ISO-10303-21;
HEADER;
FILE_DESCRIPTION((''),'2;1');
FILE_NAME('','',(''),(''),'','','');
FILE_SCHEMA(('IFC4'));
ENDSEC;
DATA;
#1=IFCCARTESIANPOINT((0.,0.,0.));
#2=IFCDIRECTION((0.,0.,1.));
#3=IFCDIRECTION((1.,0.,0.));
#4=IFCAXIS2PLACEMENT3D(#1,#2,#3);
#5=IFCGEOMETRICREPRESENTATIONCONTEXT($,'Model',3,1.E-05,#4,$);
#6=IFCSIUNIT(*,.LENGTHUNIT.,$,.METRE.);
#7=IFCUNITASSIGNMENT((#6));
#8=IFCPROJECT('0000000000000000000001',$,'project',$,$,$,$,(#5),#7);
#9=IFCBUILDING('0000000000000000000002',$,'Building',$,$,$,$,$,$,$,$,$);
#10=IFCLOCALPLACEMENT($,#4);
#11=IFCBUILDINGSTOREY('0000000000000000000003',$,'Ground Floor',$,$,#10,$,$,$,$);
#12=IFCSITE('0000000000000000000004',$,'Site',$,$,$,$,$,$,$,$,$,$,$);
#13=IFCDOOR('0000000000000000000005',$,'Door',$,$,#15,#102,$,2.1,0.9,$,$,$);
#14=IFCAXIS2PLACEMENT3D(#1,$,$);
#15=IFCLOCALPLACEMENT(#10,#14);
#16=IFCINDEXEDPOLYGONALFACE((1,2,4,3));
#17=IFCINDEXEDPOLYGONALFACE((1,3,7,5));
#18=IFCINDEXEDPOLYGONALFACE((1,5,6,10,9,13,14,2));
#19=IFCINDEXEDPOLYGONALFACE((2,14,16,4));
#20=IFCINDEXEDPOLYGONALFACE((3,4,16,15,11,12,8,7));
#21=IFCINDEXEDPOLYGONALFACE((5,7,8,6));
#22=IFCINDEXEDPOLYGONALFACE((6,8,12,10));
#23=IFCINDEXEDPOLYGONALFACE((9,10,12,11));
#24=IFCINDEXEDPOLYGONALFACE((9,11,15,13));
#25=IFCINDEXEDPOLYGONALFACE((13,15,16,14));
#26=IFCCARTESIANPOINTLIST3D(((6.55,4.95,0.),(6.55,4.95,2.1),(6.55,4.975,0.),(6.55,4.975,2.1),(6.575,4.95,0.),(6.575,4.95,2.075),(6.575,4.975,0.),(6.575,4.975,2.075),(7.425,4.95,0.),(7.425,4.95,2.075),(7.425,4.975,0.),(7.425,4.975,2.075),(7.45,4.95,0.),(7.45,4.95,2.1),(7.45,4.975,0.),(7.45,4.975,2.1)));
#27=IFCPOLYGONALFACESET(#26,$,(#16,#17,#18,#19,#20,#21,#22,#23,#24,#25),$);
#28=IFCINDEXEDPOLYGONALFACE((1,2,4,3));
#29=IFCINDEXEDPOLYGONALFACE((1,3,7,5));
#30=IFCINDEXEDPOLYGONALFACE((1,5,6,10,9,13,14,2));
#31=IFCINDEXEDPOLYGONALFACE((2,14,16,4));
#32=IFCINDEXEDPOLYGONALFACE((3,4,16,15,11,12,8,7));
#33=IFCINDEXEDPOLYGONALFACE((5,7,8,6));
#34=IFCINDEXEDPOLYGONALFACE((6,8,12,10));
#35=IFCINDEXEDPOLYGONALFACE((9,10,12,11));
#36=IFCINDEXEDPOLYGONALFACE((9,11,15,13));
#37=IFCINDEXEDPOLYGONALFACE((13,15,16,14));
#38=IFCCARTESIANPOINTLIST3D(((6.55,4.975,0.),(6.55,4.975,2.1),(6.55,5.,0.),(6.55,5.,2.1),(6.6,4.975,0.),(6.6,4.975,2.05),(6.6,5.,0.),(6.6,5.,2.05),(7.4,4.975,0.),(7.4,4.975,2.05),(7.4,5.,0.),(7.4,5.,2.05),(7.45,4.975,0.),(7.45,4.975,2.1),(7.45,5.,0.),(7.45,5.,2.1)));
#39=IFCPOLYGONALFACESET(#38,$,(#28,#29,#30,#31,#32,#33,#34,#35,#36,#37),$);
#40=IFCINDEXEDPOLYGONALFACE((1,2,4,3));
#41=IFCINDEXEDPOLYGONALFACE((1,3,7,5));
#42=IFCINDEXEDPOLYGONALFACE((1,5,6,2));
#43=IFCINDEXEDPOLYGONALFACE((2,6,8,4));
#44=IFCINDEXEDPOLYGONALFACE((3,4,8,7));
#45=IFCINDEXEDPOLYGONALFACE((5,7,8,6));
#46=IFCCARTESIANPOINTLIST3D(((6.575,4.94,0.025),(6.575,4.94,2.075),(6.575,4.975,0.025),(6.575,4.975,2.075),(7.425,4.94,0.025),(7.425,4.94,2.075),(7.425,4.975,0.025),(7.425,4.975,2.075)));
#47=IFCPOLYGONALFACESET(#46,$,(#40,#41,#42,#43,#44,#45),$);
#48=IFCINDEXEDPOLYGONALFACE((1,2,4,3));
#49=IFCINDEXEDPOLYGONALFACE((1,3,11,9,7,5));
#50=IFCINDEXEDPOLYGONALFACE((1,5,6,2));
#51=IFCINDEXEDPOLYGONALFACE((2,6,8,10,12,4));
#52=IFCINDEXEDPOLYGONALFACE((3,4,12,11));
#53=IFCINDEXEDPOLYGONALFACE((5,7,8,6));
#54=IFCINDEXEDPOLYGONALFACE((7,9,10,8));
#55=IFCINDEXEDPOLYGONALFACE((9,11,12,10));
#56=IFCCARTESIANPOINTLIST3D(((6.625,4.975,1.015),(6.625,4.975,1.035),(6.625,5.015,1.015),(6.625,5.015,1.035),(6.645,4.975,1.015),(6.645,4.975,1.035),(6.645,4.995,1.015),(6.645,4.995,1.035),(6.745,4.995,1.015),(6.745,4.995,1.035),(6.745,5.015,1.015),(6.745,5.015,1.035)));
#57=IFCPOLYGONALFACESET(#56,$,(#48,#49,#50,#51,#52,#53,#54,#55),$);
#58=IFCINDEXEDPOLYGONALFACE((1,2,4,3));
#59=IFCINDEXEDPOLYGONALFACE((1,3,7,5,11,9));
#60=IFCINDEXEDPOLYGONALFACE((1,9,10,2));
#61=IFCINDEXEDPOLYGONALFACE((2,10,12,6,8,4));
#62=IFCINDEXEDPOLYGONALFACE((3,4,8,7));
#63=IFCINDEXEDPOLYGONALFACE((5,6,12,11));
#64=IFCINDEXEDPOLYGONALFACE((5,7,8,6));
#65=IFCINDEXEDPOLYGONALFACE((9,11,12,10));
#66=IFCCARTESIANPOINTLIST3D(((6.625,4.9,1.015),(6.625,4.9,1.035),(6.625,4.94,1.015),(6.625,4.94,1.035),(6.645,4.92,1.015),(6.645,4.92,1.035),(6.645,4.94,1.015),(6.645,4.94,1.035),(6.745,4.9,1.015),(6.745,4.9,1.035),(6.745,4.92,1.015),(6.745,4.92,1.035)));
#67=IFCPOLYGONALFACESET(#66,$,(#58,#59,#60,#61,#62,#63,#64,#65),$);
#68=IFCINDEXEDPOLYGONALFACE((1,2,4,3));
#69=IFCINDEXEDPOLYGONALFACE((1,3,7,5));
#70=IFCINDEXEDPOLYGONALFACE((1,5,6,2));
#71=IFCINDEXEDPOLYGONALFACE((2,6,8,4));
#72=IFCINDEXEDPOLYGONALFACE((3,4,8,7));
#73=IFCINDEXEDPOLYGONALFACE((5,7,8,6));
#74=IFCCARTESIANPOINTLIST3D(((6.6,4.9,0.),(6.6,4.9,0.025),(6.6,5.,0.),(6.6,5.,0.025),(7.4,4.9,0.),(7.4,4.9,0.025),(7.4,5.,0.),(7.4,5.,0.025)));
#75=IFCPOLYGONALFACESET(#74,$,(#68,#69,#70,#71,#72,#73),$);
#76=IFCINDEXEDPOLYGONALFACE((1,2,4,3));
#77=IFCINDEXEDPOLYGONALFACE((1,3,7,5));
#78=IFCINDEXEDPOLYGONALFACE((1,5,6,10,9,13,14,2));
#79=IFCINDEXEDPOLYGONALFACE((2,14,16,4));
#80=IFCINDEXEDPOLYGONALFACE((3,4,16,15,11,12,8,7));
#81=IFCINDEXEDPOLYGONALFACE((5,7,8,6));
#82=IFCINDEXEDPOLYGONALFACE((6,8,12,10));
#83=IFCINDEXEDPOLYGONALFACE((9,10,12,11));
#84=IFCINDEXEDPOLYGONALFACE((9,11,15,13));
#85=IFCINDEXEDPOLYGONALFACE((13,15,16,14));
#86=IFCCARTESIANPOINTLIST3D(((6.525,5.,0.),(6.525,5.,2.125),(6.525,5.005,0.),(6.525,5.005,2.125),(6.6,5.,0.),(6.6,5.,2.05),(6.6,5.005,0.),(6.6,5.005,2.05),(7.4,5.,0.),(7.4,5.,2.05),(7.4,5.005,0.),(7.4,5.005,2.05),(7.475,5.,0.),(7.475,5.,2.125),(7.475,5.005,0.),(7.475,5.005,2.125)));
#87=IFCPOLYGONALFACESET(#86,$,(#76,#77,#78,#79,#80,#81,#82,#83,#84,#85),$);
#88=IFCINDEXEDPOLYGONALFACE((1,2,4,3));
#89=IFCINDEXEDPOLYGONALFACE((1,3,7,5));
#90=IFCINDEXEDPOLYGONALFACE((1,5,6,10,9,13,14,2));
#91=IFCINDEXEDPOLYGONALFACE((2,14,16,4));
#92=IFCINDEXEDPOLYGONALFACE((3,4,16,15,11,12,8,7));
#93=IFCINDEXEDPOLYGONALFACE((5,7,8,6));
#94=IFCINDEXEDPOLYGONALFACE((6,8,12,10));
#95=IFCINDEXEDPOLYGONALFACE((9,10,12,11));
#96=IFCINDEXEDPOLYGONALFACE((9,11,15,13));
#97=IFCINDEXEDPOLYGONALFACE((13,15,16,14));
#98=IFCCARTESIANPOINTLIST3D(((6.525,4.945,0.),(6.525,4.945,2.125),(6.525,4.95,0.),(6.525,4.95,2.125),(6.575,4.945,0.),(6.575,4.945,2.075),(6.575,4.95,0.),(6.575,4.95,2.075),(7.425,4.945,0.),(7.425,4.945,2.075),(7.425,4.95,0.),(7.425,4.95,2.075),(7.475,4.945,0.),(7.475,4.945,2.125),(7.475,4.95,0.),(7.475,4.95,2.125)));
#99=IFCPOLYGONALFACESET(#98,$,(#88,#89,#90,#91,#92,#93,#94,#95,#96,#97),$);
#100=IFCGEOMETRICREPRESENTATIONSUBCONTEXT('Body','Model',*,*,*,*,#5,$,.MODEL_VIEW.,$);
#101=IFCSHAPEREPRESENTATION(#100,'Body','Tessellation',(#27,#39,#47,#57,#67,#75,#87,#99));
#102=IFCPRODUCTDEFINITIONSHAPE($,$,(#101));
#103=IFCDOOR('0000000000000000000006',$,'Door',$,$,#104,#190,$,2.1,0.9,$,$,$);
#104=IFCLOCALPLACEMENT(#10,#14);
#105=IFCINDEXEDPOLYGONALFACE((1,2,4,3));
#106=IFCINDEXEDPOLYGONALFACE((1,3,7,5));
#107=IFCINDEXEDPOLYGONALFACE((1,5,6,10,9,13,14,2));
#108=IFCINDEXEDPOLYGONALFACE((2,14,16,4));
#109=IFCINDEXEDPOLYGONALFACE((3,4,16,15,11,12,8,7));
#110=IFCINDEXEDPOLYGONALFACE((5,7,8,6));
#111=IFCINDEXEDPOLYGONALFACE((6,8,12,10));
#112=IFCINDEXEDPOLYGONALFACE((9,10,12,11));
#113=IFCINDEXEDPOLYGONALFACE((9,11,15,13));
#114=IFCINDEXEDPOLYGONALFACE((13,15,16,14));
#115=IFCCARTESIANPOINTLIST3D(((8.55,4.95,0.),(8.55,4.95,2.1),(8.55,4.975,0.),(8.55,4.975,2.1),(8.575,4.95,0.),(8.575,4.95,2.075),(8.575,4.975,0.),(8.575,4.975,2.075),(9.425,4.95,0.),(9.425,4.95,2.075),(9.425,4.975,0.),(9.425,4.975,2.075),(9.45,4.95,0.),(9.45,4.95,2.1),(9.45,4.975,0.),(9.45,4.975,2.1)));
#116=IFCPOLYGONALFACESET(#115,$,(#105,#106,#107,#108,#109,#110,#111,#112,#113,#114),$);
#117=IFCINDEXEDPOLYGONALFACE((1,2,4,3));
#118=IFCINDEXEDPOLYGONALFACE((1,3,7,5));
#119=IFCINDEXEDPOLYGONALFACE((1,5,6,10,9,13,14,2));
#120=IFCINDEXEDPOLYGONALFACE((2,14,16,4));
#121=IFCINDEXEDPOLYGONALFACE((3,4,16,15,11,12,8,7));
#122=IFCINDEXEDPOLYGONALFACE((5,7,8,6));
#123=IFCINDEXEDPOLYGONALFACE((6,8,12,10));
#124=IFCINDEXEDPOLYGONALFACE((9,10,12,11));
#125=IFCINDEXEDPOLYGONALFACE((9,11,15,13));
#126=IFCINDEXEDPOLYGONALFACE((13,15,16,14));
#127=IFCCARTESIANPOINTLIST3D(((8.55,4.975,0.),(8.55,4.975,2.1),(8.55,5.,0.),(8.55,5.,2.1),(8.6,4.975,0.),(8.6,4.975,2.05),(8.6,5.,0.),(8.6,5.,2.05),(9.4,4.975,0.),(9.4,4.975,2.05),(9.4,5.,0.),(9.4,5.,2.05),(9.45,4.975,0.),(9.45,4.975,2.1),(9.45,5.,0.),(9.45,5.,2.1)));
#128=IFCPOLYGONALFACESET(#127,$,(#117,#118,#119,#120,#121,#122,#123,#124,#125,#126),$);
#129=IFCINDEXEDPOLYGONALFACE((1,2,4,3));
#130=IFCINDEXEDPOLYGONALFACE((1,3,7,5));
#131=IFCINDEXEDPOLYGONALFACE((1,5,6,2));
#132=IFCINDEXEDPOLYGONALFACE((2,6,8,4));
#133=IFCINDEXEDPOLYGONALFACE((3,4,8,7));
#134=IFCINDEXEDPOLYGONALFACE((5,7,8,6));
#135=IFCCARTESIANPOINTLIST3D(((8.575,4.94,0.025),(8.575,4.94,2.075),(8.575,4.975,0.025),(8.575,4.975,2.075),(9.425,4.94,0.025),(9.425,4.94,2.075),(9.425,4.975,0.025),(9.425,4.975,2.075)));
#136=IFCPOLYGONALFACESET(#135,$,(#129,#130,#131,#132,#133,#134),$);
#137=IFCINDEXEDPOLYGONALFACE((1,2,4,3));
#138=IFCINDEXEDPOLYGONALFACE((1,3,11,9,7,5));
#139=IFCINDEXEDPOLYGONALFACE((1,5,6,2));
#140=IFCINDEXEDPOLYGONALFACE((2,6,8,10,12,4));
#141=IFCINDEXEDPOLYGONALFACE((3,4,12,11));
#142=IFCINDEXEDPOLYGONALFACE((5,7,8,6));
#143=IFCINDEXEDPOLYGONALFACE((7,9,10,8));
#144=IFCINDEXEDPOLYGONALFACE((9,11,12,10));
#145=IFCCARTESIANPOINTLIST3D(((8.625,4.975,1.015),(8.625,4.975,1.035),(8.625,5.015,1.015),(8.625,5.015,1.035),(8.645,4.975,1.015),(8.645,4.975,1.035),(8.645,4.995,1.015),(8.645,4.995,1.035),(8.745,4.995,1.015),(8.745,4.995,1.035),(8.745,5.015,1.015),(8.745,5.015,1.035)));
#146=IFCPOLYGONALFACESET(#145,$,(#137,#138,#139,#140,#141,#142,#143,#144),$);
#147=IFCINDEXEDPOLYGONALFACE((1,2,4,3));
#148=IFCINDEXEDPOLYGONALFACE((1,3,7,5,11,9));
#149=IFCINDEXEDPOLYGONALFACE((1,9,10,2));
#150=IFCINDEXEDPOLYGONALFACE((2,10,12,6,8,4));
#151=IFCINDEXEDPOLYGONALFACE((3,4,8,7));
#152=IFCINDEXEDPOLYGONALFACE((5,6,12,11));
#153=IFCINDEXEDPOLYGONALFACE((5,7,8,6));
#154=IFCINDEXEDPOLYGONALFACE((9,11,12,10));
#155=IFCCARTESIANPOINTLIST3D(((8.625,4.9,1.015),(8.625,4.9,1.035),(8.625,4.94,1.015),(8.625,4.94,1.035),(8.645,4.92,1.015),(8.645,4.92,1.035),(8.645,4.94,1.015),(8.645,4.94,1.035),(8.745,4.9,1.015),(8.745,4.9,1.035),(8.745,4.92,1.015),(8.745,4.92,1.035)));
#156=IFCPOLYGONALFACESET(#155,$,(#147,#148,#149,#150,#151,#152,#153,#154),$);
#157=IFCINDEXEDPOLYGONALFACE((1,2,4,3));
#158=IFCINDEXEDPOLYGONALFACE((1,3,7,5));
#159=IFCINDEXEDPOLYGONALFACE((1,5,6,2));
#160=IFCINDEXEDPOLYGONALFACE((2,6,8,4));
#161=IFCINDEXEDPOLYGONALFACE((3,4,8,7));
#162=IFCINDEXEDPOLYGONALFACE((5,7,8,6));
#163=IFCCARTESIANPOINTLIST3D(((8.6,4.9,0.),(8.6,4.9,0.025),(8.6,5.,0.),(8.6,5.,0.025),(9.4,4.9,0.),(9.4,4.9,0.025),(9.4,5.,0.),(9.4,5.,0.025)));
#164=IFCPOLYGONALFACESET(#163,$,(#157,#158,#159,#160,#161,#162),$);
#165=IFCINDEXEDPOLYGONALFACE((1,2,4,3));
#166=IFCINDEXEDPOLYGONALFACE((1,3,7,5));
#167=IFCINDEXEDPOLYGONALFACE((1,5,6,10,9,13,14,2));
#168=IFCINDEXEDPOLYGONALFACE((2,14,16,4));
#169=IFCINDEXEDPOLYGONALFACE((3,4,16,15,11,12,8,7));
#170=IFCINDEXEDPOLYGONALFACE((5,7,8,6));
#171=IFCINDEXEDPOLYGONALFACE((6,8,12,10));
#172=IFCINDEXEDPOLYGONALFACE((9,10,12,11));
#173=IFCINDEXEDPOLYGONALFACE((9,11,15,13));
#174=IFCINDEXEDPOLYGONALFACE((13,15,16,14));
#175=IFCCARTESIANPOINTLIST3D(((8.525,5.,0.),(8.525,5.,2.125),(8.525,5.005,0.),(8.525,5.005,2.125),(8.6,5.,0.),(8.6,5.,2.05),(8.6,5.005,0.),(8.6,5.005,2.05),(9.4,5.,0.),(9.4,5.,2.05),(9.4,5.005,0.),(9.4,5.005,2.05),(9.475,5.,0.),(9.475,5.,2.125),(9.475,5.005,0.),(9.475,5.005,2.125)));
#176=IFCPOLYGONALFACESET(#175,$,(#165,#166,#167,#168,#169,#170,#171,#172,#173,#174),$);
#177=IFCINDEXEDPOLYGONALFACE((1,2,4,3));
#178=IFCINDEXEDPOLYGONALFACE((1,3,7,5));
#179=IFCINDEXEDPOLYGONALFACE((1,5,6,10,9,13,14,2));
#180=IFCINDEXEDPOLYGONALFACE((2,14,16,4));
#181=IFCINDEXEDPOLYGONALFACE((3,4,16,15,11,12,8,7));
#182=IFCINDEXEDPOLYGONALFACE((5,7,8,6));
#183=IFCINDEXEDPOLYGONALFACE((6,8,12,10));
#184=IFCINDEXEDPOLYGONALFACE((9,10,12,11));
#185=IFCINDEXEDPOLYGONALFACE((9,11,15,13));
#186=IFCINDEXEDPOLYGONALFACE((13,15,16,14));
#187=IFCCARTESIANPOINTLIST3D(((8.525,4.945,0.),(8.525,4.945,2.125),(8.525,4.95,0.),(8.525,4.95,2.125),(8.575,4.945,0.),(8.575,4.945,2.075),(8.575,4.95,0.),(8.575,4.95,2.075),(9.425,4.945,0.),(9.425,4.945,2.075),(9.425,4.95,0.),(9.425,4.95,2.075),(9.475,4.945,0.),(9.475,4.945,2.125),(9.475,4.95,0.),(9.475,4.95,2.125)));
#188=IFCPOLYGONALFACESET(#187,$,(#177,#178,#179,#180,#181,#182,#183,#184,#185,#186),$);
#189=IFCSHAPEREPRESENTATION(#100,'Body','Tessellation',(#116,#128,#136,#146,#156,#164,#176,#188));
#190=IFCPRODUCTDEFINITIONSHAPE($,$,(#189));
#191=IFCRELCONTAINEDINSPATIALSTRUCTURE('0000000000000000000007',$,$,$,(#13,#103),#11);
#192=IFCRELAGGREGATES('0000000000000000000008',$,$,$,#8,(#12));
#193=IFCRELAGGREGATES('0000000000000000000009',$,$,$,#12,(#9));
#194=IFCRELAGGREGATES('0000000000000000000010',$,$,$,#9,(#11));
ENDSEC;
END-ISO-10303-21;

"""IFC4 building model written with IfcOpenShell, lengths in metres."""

from ifc_helpers import new_model, si_unit, frame, origin_with_axes, place, context, subcontext, project, spatial, line, indexed_curve, outline, extrude, element, save


model = new_model("IFC4")

# Units and contexts
model_context = context("Model", 3, precision=1e-05, world=origin_with_axes())
body_context = subcontext(model_context, "Body", "Model", "MODEL_VIEW")
ifc_project = project(units=[si_unit("LENGTHUNIT", "METRE")], contexts=[model_context])

# Site, building, storey
site = spatial("IfcSite", under=ifc_project, Name="Site")
building = spatial("IfcBuilding", under=site, Name="Building")
storey_placement = place(None, origin_with_axes())
storey = spatial("IfcBuildingStorey", under=building, at=storey_placement, Name="Ground Floor")

# Doors
door_1_placement = place(storey_placement, frame((7.45, 5.0, 0.0), z_axis=(0.0, 0.0, 1.0), x_axis=(-1.0, 0.0, 0.0)))
element("IfcDoor", 1, at=door_1_placement, inside=storey, Name="Door", OverallHeight=2.1, OverallWidth=0.9, context=body_context, shape_type="SweptSolid", body=[
    extrude(outline(indexed_curve([(0.0, 0.0), (0.0, 2.1), (0.9, 2.1), (0.9, 0.0), (0.875, 0.0), (0.875, 2.075), (0.025, 2.075), (0.025, 0.0)], segments=[line(1, 2, 3, 4, 5, 6, 7, 8, 1)])), frame((0.0, 0.025, 0.0), z_axis=(0.0, -1.0, 0.0), x_axis=(1.0, 0.0, 0.0)), (0.0, 0.0, -1.0), 0.025),
    extrude(outline(indexed_curve([(0.0, 0.0), (0.0, 2.1), (0.9, 2.1), (0.9, 0.0), (0.85, 0.0), (0.85, 2.05), (0.05, 2.05), (0.05, 0.0)], segments=[line(1, 2, 3, 4, 5, 6, 7, 8, 1)])), frame((0.0, 0.0, 0.0), z_axis=(0.0, -1.0, 0.0), x_axis=(1.0, 0.0, 0.0)), (0.0, 0.0, -1.0), 0.025),
    extrude(outline(indexed_curve([(0.0, 0.0), (0.85, 0.0), (0.85, 0.035), (0.0, 0.035)], segments=[line(1, 2, 3, 4, 1)])), frame((0.025, 0.025, 0.025), z_axis=(0.0, 0.0, 1.0), x_axis=(1.0, 0.0, 0.0)), (0.0, 0.0, 1.0), 2.05),
    extrude(outline(indexed_curve([(0.0, 0.0), (0.0, -0.04), (-0.12, -0.04), (-0.12, -0.02), (-0.02, -0.02), (-0.02, 0.0)], segments=[line(1, 2, 3, 4, 5, 6, 1)])), frame((0.825, 0.025, 1.015), z_axis=(0.0, 0.0, 1.0), x_axis=(1.0, 0.0, 0.0)), (0.0, 0.0, 1.0), 0.02),
    extrude(outline(indexed_curve([(0.0, 0.0), (0.0, 0.04), (-0.12, 0.04), (-0.12, 0.02), (-0.02, 0.02), (-0.02, 0.0)], segments=[line(1, 2, 3, 4, 5, 6, 1)])), frame((0.825, 0.06, 1.015), z_axis=(0.0, 0.0, 1.0), x_axis=(1.0, 0.0, 0.0)), (0.0, 0.0, 1.0), 0.02),
    extrude(outline(indexed_curve([(0.0, 0.0), (0.8, 0.0), (0.8, 0.1), (0.0, 0.1)], segments=[line(1, 2, 3, 4, 1)])), frame((0.05, 0.0, 0.0), z_axis=(0.0, 0.0, 1.0), x_axis=(1.0, 0.0, 0.0)), (0.0, 0.0, 1.0), 0.025),
    extrude(outline(indexed_curve([(0.0, 0.0), (0.0, 2.125), (0.95, 2.125), (0.95, 0.0), (0.875, 0.0), (0.875, 2.05), (0.075, 2.05), (0.075, 0.0)], segments=[line(1, 2, 3, 4, 5, 6, 7, 8, 1)])), frame((-0.025, -0.005, 0.0), z_axis=(0.0, -1.0, 0.0), x_axis=(1.0, 0.0, 0.0)), (0.0, 0.0, -1.0), 0.005),
    extrude(outline(indexed_curve([(0.0, 0.0), (0.0, 2.125), (0.95, 2.125), (0.95, 0.0), (0.9, 0.0), (0.9, 2.075), (0.05, 2.075), (0.05, 0.0)], segments=[line(1, 2, 3, 4, 5, 6, 7, 8, 1)])), frame((-0.025, 0.05, 0.0), z_axis=(0.0, -1.0, 0.0), x_axis=(1.0, 0.0, 0.0)), (0.0, 0.0, -1.0), 0.005),
])
door_2_placement = place(storey_placement, frame((9.45, 5.0, 0.0), z_axis=(0.0, 0.0, 1.0), x_axis=(-1.0, 0.0, 0.0)))
element("IfcDoor", 2, at=door_2_placement, inside=storey, Name="Door", OverallHeight=2.1, OverallWidth=0.9, context=body_context, shape_type="SweptSolid", body=[
    extrude(outline(indexed_curve([(0.0, 0.0), (0.0, 2.1), (0.9, 2.1), (0.9, 0.0), (0.875, 0.0), (0.875, 2.075), (0.025, 2.075), (0.025, 0.0)], segments=[line(1, 2, 3, 4, 5, 6, 7, 8, 1)])), frame((0.0, 0.025, 0.0), z_axis=(0.0, -1.0, 0.0), x_axis=(1.0, 0.0, 0.0)), (0.0, 0.0, -1.0), 0.025),
    extrude(outline(indexed_curve([(0.0, 0.0), (0.0, 2.1), (0.9, 2.1), (0.9, 0.0), (0.85, 0.0), (0.85, 2.05), (0.05, 2.05), (0.05, 0.0)], segments=[line(1, 2, 3, 4, 5, 6, 7, 8, 1)])), frame((0.0, 0.0, 0.0), z_axis=(0.0, -1.0, 0.0), x_axis=(1.0, 0.0, 0.0)), (0.0, 0.0, -1.0), 0.025),
    extrude(outline(indexed_curve([(0.0, 0.0), (0.85, 0.0), (0.85, 0.035), (0.0, 0.035)], segments=[line(1, 2, 3, 4, 1)])), frame((0.025, 0.025, 0.025), z_axis=(0.0, 0.0, 1.0), x_axis=(1.0, 0.0, 0.0)), (0.0, 0.0, 1.0), 2.05),
    extrude(outline(indexed_curve([(0.0, 0.0), (0.0, -0.04), (-0.12, -0.04), (-0.12, -0.02), (-0.02, -0.02), (-0.02, 0.0)], segments=[line(1, 2, 3, 4, 5, 6, 1)])), frame((0.825, 0.025, 1.015), z_axis=(0.0, 0.0, 1.0), x_axis=(1.0, 0.0, 0.0)), (0.0, 0.0, 1.0), 0.02),
    extrude(outline(indexed_curve([(0.0, 0.0), (0.0, 0.04), (-0.12, 0.04), (-0.12, 0.02), (-0.02, 0.02), (-0.02, 0.0)], segments=[line(1, 2, 3, 4, 5, 6, 1)])), frame((0.825, 0.06, 1.015), z_axis=(0.0, 0.0, 1.0), x_axis=(1.0, 0.0, 0.0)), (0.0, 0.0, 1.0), 0.02),
    extrude(outline(indexed_curve([(0.0, 0.0), (0.8, 0.0), (0.8, 0.1), (0.0, 0.1)], segments=[line(1, 2, 3, 4, 1)])), frame((0.05, 0.0, 0.0), z_axis=(0.0, 0.0, 1.0), x_axis=(1.0, 0.0, 0.0)), (0.0, 0.0, 1.0), 0.025),
    extrude(outline(indexed_curve([(0.0, 0.0), (0.0, 2.125), (0.95, 2.125), (0.95, 0.0), (0.875, 0.0), (0.875, 2.05), (0.075, 2.05), (0.075, 0.0)], segments=[line(1, 2, 3, 4, 5, 6, 7, 8, 1)])), frame((-0.025, -0.005, 0.0), z_axis=(0.0, -1.0, 0.0), x_axis=(1.0, 0.0, 0.0)), (0.0, 0.0, -1.0), 0.005),
    extrude(outline(indexed_curve([(0.0, 0.0), (0.0, 2.125), (0.95, 2.125), (0.95, 0.0), (0.9, 0.0), (0.9, 2.075), (0.05, 2.075), (0.05, 0.0)], segments=[line(1, 2, 3, 4, 5, 6, 7, 8, 1)])), frame((-0.025, 0.05, 0.0), z_axis=(0.0, -1.0, 0.0), x_axis=(1.0, 0.0, 0.0)), (0.0, 0.0, -1.0), 0.005),
])

save(model, "model.ifc")
